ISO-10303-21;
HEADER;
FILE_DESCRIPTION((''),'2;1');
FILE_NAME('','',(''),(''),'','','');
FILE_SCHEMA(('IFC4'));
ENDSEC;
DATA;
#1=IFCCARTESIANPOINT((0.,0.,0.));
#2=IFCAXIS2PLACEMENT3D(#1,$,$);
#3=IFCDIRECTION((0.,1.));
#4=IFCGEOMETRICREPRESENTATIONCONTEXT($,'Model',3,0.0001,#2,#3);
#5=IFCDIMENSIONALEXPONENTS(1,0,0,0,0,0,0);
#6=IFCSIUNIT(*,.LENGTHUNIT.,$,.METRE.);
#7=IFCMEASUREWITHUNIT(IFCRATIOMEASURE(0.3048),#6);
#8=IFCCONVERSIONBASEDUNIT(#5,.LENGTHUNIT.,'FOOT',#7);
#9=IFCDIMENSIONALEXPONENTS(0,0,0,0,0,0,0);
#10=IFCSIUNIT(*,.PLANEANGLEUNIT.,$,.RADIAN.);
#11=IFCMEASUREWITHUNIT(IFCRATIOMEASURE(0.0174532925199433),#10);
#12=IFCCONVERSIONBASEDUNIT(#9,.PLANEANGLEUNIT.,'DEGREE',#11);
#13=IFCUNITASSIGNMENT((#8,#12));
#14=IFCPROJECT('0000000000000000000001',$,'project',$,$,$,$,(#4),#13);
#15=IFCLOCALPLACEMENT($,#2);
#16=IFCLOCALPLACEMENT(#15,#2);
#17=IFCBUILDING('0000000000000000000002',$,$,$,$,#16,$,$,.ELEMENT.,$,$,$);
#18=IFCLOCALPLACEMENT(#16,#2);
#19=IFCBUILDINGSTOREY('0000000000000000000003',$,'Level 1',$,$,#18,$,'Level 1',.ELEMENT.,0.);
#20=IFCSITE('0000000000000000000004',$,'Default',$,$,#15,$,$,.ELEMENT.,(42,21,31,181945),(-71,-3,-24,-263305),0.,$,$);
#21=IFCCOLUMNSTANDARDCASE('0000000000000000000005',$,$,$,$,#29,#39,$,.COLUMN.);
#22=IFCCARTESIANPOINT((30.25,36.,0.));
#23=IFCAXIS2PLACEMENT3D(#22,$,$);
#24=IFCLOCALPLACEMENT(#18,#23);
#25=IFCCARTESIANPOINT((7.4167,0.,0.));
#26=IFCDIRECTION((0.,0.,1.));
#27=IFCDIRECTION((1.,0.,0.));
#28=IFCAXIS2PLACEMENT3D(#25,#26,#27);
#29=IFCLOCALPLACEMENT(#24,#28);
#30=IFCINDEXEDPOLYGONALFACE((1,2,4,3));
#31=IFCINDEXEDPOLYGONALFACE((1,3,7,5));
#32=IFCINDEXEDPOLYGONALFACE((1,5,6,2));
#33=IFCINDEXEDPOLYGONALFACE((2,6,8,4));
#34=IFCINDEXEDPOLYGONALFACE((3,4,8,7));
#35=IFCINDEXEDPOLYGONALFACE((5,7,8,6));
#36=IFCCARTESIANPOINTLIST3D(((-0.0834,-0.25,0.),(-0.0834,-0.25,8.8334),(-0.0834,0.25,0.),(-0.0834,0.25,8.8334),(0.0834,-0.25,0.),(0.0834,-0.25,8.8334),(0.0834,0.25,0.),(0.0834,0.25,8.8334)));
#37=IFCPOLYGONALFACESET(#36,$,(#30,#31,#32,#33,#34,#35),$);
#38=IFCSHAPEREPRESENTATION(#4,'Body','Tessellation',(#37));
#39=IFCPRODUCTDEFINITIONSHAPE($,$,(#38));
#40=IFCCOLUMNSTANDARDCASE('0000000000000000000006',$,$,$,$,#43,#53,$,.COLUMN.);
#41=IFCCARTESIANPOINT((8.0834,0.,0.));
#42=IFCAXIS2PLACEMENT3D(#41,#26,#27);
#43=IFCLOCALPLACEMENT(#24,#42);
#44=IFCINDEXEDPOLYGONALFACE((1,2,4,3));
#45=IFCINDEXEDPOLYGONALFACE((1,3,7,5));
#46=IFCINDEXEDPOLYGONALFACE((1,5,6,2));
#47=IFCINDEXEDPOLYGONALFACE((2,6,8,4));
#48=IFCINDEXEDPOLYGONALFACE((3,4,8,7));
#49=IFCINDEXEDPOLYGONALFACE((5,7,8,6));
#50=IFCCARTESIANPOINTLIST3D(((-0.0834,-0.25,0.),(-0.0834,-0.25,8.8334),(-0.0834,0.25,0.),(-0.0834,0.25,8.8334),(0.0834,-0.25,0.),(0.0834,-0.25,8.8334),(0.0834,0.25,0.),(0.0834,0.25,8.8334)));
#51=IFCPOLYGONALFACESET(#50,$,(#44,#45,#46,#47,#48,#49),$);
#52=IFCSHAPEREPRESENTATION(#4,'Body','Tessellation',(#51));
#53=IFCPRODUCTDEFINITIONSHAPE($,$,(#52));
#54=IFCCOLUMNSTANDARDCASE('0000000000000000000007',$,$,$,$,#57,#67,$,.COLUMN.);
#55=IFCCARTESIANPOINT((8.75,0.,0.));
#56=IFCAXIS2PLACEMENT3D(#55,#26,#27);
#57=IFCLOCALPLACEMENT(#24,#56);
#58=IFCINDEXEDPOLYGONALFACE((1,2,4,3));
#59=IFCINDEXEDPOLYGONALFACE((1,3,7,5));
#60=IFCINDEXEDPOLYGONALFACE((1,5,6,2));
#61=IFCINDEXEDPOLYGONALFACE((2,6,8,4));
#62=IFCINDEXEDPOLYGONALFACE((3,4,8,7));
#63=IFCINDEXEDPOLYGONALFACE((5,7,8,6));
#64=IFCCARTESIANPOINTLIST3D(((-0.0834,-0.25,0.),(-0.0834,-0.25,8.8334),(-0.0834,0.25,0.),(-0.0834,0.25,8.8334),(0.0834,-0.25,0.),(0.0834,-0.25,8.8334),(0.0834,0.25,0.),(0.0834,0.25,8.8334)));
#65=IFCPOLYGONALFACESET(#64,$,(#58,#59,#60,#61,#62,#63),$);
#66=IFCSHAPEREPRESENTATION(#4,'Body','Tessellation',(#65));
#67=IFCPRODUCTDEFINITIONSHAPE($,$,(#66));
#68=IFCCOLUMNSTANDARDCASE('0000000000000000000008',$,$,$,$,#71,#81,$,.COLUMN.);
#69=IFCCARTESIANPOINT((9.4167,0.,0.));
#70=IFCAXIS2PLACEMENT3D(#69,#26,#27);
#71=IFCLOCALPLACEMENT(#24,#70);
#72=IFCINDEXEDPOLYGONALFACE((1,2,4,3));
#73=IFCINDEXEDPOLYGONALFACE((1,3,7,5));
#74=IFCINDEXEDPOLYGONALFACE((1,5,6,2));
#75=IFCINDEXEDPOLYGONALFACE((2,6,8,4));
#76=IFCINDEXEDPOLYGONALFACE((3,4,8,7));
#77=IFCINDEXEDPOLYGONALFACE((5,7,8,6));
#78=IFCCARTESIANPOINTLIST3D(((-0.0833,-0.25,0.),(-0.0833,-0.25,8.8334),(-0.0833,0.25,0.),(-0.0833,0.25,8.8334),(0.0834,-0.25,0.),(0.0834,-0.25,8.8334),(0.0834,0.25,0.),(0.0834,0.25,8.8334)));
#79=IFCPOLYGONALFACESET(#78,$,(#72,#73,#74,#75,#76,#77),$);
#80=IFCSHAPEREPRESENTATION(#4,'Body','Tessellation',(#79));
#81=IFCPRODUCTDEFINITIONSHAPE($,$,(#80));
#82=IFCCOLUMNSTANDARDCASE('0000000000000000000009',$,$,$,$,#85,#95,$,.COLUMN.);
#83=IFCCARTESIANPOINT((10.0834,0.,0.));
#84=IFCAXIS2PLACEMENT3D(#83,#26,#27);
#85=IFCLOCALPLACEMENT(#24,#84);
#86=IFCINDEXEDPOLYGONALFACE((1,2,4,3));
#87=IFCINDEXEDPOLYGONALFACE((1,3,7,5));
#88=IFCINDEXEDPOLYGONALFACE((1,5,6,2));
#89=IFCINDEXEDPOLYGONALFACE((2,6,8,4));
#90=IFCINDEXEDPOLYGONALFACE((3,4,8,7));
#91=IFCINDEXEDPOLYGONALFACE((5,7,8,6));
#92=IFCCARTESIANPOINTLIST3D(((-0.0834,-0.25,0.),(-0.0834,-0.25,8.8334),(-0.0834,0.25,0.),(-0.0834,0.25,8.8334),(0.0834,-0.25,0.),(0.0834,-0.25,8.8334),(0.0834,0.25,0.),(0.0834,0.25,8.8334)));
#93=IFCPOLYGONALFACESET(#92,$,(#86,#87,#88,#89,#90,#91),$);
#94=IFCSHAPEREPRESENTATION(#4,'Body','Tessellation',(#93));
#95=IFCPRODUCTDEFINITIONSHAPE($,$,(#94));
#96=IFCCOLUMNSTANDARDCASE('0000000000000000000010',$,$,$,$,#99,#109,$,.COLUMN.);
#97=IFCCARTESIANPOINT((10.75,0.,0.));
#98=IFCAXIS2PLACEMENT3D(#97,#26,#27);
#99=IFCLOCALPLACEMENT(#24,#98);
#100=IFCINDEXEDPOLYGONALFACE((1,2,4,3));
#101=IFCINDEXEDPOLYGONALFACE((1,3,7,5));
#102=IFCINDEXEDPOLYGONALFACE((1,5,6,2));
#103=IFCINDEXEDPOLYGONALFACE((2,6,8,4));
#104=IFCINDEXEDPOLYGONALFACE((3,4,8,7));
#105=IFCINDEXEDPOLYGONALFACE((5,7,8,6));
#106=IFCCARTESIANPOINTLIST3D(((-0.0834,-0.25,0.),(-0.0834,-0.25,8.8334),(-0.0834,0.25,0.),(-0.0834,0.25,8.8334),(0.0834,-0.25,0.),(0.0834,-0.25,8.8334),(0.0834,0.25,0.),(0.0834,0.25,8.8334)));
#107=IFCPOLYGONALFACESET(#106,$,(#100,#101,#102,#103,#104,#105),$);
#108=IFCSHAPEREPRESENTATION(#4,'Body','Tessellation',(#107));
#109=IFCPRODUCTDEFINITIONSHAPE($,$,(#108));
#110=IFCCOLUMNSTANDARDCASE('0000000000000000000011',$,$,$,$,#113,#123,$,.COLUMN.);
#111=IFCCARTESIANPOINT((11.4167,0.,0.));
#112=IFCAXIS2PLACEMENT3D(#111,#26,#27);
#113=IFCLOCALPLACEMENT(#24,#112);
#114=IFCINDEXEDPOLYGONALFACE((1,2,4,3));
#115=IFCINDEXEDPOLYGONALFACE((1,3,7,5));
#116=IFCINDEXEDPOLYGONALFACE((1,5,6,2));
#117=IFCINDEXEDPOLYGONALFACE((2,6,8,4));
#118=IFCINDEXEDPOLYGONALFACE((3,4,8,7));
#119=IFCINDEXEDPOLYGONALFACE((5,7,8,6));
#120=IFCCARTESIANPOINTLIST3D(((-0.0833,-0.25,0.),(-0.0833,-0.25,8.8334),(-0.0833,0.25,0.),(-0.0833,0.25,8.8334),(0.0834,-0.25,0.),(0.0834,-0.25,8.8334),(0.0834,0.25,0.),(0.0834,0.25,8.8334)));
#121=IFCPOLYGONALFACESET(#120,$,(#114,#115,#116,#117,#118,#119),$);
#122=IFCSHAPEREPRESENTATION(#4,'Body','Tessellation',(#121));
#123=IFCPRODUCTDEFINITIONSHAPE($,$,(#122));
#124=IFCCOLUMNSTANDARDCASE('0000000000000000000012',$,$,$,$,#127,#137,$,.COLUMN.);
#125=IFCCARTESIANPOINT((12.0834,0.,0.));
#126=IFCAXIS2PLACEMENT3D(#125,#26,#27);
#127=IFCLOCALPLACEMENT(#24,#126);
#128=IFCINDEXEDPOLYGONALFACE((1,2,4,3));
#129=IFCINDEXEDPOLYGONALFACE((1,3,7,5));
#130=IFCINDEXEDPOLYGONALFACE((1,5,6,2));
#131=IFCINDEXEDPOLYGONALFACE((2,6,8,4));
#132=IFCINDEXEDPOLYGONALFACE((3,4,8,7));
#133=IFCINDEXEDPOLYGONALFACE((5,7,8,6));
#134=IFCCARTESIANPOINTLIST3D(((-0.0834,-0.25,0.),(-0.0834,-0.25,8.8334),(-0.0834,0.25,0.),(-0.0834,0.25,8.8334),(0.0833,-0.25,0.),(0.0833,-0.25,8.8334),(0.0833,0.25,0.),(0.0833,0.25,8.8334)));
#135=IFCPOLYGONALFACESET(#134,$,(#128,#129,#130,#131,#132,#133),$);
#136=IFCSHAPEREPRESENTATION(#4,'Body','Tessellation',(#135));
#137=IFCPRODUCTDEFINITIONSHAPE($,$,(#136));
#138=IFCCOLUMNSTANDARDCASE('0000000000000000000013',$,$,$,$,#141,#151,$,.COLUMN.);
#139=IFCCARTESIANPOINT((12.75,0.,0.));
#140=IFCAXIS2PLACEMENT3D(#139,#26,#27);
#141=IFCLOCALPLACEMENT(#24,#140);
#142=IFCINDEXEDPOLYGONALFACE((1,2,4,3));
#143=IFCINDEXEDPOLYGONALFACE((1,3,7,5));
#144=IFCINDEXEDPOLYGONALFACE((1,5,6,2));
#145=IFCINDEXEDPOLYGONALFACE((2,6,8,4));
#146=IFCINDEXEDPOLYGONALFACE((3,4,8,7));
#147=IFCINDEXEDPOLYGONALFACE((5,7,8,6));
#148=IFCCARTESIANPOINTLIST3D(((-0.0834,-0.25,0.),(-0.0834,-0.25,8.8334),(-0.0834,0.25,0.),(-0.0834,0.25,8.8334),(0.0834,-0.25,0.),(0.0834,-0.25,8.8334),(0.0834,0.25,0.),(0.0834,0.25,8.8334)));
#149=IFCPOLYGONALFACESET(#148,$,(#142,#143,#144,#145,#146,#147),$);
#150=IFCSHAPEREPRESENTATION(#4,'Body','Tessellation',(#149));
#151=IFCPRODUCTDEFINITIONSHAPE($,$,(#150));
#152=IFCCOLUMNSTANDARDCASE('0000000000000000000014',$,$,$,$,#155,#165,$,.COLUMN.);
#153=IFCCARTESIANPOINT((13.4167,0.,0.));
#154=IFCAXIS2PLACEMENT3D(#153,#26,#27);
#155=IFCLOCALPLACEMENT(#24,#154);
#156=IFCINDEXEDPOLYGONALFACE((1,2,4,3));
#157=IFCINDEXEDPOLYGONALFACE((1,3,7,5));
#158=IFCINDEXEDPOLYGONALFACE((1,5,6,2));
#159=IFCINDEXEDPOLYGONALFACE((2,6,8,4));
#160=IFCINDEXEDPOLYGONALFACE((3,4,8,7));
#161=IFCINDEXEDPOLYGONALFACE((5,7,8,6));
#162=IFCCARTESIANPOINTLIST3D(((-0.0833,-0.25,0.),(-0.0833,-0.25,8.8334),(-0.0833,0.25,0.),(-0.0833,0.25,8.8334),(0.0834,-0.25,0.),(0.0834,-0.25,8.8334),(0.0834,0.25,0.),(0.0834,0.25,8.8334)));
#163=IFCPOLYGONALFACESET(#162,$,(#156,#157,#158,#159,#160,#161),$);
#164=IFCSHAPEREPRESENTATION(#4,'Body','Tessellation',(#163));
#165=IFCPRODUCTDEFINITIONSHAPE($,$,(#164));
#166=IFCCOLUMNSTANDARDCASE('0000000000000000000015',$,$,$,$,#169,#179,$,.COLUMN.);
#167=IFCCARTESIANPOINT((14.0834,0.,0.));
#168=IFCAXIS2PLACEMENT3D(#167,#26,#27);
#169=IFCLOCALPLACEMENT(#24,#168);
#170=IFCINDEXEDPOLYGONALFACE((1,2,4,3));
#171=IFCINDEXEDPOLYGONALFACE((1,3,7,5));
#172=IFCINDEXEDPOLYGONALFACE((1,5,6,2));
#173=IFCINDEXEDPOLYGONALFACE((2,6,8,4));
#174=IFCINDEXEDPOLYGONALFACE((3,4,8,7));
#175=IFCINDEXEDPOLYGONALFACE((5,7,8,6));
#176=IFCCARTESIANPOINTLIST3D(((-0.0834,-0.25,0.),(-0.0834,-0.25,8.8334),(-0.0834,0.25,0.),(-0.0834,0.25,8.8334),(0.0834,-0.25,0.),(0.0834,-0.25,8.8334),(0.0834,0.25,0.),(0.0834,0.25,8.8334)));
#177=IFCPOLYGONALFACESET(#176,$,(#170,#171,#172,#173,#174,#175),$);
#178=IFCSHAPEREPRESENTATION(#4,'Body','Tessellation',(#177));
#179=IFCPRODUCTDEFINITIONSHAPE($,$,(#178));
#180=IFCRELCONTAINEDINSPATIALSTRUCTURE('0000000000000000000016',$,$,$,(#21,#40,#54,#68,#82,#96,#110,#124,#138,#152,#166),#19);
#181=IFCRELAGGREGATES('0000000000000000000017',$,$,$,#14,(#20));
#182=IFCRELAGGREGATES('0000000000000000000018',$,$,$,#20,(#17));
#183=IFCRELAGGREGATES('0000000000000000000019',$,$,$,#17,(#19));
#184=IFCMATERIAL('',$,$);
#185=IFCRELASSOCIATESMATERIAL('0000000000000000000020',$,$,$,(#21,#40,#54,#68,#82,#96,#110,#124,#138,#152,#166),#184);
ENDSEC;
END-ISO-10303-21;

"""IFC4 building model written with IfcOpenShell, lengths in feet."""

from ifc_helpers import new_model, entity, si_unit, converted_unit, direction, frame, origin, place, context, project, spatial, rectangle, extrude, material, element, save


model = new_model("IFC4")

# Units and contexts
model_context = context("Model", 3, precision=0.0001, world=origin(), true_north=direction((0.0, 1.0)))
ifc_project = project(units=[converted_unit("LENGTHUNIT", "FOOT", entity("IfcRatioMeasure", 0.3048), si_unit("LENGTHUNIT", "METRE"), dimensions=[1, 0, 0, 0, 0, 0, 0]), converted_unit("PLANEANGLEUNIT", "DEGREE", entity("IfcRatioMeasure", 0.0174532925199433), si_unit("PLANEANGLEUNIT", "RADIAN"), dimensions=[0, 0, 0, 0, 0, 0, 0])], contexts=[model_context])

# Site, building, storey
site_placement = place(None, origin())
site = spatial("IfcSite", under=ifc_project, at=site_placement, Name="Default", CompositionType="ELEMENT", RefLatitude=(42, 21, 31, 181945), RefLongitude=(-71, -3, -24, -263305), RefElevation=0.0)
building_placement = place(site_placement, origin())
building = spatial("IfcBuilding", under=site, at=building_placement, CompositionType="ELEMENT")
storey_placement = place(building_placement, origin())
storey = spatial("IfcBuildingStorey", under=building, at=storey_placement, Name="Level 1", LongName="Level 1", CompositionType="ELEMENT", Elevation=0.0)

# Columns
ifc_material_1 = material(Name="")
placement_1 = place(storey_placement, frame((30.25, 36.0, 0.0)))
for number, where, z_axis, x_axis in (
    (1, (7.4167, 0.0, 0.0), (0.0, 0.0, 1.0), (1.0, 0.0, 0.0)),
    (2, (8.0834, 0.0, 0.0), (0.0, 0.0, 1.0), (1.0, 0.0, 0.0)),
    (3, (8.75, 0.0, 0.0), (0.0, 0.0, 1.0), (1.0, 0.0, 0.0)),
    (4, (9.4167, 0.0, 0.0), (0.0, 0.0, 1.0), (1.0, 0.0, 0.0)),
    (5, (10.0834, 0.0, 0.0), (0.0, 0.0, 1.0), (1.0, 0.0, 0.0)),
    (6, (10.75, 0.0, 0.0), (0.0, 0.0, 1.0), (1.0, 0.0, 0.0)),
    (7, (11.4167, 0.0, 0.0), (0.0, 0.0, 1.0), (1.0, 0.0, 0.0)),
    (8, (12.0834, 0.0, 0.0), (0.0, 0.0, 1.0), (1.0, 0.0, 0.0)),
    (9, (12.75, 0.0, 0.0), (0.0, 0.0, 1.0), (1.0, 0.0, 0.0)),
    (10, (13.4167, 0.0, 0.0), (0.0, 0.0, 1.0), (1.0, 0.0, 0.0)),
    (11, (14.0834, 0.0, 0.0), (0.0, 0.0, 1.0), (1.0, 0.0, 0.0)),
):
    element("IfcColumnStandardCase", number, at=place(placement_1, frame(where, z_axis=z_axis, x_axis=x_axis)), inside=storey, material=ifc_material_1, PredefinedType="COLUMN", context=model_context, shape_type="SweptSolid", body=[
        extrude(rectangle(XDim=0.1667, YDim=0.5), origin(), (0.0, 0.0, 1.0), 8.8334),
    ])

save(model, "model.ifc")
